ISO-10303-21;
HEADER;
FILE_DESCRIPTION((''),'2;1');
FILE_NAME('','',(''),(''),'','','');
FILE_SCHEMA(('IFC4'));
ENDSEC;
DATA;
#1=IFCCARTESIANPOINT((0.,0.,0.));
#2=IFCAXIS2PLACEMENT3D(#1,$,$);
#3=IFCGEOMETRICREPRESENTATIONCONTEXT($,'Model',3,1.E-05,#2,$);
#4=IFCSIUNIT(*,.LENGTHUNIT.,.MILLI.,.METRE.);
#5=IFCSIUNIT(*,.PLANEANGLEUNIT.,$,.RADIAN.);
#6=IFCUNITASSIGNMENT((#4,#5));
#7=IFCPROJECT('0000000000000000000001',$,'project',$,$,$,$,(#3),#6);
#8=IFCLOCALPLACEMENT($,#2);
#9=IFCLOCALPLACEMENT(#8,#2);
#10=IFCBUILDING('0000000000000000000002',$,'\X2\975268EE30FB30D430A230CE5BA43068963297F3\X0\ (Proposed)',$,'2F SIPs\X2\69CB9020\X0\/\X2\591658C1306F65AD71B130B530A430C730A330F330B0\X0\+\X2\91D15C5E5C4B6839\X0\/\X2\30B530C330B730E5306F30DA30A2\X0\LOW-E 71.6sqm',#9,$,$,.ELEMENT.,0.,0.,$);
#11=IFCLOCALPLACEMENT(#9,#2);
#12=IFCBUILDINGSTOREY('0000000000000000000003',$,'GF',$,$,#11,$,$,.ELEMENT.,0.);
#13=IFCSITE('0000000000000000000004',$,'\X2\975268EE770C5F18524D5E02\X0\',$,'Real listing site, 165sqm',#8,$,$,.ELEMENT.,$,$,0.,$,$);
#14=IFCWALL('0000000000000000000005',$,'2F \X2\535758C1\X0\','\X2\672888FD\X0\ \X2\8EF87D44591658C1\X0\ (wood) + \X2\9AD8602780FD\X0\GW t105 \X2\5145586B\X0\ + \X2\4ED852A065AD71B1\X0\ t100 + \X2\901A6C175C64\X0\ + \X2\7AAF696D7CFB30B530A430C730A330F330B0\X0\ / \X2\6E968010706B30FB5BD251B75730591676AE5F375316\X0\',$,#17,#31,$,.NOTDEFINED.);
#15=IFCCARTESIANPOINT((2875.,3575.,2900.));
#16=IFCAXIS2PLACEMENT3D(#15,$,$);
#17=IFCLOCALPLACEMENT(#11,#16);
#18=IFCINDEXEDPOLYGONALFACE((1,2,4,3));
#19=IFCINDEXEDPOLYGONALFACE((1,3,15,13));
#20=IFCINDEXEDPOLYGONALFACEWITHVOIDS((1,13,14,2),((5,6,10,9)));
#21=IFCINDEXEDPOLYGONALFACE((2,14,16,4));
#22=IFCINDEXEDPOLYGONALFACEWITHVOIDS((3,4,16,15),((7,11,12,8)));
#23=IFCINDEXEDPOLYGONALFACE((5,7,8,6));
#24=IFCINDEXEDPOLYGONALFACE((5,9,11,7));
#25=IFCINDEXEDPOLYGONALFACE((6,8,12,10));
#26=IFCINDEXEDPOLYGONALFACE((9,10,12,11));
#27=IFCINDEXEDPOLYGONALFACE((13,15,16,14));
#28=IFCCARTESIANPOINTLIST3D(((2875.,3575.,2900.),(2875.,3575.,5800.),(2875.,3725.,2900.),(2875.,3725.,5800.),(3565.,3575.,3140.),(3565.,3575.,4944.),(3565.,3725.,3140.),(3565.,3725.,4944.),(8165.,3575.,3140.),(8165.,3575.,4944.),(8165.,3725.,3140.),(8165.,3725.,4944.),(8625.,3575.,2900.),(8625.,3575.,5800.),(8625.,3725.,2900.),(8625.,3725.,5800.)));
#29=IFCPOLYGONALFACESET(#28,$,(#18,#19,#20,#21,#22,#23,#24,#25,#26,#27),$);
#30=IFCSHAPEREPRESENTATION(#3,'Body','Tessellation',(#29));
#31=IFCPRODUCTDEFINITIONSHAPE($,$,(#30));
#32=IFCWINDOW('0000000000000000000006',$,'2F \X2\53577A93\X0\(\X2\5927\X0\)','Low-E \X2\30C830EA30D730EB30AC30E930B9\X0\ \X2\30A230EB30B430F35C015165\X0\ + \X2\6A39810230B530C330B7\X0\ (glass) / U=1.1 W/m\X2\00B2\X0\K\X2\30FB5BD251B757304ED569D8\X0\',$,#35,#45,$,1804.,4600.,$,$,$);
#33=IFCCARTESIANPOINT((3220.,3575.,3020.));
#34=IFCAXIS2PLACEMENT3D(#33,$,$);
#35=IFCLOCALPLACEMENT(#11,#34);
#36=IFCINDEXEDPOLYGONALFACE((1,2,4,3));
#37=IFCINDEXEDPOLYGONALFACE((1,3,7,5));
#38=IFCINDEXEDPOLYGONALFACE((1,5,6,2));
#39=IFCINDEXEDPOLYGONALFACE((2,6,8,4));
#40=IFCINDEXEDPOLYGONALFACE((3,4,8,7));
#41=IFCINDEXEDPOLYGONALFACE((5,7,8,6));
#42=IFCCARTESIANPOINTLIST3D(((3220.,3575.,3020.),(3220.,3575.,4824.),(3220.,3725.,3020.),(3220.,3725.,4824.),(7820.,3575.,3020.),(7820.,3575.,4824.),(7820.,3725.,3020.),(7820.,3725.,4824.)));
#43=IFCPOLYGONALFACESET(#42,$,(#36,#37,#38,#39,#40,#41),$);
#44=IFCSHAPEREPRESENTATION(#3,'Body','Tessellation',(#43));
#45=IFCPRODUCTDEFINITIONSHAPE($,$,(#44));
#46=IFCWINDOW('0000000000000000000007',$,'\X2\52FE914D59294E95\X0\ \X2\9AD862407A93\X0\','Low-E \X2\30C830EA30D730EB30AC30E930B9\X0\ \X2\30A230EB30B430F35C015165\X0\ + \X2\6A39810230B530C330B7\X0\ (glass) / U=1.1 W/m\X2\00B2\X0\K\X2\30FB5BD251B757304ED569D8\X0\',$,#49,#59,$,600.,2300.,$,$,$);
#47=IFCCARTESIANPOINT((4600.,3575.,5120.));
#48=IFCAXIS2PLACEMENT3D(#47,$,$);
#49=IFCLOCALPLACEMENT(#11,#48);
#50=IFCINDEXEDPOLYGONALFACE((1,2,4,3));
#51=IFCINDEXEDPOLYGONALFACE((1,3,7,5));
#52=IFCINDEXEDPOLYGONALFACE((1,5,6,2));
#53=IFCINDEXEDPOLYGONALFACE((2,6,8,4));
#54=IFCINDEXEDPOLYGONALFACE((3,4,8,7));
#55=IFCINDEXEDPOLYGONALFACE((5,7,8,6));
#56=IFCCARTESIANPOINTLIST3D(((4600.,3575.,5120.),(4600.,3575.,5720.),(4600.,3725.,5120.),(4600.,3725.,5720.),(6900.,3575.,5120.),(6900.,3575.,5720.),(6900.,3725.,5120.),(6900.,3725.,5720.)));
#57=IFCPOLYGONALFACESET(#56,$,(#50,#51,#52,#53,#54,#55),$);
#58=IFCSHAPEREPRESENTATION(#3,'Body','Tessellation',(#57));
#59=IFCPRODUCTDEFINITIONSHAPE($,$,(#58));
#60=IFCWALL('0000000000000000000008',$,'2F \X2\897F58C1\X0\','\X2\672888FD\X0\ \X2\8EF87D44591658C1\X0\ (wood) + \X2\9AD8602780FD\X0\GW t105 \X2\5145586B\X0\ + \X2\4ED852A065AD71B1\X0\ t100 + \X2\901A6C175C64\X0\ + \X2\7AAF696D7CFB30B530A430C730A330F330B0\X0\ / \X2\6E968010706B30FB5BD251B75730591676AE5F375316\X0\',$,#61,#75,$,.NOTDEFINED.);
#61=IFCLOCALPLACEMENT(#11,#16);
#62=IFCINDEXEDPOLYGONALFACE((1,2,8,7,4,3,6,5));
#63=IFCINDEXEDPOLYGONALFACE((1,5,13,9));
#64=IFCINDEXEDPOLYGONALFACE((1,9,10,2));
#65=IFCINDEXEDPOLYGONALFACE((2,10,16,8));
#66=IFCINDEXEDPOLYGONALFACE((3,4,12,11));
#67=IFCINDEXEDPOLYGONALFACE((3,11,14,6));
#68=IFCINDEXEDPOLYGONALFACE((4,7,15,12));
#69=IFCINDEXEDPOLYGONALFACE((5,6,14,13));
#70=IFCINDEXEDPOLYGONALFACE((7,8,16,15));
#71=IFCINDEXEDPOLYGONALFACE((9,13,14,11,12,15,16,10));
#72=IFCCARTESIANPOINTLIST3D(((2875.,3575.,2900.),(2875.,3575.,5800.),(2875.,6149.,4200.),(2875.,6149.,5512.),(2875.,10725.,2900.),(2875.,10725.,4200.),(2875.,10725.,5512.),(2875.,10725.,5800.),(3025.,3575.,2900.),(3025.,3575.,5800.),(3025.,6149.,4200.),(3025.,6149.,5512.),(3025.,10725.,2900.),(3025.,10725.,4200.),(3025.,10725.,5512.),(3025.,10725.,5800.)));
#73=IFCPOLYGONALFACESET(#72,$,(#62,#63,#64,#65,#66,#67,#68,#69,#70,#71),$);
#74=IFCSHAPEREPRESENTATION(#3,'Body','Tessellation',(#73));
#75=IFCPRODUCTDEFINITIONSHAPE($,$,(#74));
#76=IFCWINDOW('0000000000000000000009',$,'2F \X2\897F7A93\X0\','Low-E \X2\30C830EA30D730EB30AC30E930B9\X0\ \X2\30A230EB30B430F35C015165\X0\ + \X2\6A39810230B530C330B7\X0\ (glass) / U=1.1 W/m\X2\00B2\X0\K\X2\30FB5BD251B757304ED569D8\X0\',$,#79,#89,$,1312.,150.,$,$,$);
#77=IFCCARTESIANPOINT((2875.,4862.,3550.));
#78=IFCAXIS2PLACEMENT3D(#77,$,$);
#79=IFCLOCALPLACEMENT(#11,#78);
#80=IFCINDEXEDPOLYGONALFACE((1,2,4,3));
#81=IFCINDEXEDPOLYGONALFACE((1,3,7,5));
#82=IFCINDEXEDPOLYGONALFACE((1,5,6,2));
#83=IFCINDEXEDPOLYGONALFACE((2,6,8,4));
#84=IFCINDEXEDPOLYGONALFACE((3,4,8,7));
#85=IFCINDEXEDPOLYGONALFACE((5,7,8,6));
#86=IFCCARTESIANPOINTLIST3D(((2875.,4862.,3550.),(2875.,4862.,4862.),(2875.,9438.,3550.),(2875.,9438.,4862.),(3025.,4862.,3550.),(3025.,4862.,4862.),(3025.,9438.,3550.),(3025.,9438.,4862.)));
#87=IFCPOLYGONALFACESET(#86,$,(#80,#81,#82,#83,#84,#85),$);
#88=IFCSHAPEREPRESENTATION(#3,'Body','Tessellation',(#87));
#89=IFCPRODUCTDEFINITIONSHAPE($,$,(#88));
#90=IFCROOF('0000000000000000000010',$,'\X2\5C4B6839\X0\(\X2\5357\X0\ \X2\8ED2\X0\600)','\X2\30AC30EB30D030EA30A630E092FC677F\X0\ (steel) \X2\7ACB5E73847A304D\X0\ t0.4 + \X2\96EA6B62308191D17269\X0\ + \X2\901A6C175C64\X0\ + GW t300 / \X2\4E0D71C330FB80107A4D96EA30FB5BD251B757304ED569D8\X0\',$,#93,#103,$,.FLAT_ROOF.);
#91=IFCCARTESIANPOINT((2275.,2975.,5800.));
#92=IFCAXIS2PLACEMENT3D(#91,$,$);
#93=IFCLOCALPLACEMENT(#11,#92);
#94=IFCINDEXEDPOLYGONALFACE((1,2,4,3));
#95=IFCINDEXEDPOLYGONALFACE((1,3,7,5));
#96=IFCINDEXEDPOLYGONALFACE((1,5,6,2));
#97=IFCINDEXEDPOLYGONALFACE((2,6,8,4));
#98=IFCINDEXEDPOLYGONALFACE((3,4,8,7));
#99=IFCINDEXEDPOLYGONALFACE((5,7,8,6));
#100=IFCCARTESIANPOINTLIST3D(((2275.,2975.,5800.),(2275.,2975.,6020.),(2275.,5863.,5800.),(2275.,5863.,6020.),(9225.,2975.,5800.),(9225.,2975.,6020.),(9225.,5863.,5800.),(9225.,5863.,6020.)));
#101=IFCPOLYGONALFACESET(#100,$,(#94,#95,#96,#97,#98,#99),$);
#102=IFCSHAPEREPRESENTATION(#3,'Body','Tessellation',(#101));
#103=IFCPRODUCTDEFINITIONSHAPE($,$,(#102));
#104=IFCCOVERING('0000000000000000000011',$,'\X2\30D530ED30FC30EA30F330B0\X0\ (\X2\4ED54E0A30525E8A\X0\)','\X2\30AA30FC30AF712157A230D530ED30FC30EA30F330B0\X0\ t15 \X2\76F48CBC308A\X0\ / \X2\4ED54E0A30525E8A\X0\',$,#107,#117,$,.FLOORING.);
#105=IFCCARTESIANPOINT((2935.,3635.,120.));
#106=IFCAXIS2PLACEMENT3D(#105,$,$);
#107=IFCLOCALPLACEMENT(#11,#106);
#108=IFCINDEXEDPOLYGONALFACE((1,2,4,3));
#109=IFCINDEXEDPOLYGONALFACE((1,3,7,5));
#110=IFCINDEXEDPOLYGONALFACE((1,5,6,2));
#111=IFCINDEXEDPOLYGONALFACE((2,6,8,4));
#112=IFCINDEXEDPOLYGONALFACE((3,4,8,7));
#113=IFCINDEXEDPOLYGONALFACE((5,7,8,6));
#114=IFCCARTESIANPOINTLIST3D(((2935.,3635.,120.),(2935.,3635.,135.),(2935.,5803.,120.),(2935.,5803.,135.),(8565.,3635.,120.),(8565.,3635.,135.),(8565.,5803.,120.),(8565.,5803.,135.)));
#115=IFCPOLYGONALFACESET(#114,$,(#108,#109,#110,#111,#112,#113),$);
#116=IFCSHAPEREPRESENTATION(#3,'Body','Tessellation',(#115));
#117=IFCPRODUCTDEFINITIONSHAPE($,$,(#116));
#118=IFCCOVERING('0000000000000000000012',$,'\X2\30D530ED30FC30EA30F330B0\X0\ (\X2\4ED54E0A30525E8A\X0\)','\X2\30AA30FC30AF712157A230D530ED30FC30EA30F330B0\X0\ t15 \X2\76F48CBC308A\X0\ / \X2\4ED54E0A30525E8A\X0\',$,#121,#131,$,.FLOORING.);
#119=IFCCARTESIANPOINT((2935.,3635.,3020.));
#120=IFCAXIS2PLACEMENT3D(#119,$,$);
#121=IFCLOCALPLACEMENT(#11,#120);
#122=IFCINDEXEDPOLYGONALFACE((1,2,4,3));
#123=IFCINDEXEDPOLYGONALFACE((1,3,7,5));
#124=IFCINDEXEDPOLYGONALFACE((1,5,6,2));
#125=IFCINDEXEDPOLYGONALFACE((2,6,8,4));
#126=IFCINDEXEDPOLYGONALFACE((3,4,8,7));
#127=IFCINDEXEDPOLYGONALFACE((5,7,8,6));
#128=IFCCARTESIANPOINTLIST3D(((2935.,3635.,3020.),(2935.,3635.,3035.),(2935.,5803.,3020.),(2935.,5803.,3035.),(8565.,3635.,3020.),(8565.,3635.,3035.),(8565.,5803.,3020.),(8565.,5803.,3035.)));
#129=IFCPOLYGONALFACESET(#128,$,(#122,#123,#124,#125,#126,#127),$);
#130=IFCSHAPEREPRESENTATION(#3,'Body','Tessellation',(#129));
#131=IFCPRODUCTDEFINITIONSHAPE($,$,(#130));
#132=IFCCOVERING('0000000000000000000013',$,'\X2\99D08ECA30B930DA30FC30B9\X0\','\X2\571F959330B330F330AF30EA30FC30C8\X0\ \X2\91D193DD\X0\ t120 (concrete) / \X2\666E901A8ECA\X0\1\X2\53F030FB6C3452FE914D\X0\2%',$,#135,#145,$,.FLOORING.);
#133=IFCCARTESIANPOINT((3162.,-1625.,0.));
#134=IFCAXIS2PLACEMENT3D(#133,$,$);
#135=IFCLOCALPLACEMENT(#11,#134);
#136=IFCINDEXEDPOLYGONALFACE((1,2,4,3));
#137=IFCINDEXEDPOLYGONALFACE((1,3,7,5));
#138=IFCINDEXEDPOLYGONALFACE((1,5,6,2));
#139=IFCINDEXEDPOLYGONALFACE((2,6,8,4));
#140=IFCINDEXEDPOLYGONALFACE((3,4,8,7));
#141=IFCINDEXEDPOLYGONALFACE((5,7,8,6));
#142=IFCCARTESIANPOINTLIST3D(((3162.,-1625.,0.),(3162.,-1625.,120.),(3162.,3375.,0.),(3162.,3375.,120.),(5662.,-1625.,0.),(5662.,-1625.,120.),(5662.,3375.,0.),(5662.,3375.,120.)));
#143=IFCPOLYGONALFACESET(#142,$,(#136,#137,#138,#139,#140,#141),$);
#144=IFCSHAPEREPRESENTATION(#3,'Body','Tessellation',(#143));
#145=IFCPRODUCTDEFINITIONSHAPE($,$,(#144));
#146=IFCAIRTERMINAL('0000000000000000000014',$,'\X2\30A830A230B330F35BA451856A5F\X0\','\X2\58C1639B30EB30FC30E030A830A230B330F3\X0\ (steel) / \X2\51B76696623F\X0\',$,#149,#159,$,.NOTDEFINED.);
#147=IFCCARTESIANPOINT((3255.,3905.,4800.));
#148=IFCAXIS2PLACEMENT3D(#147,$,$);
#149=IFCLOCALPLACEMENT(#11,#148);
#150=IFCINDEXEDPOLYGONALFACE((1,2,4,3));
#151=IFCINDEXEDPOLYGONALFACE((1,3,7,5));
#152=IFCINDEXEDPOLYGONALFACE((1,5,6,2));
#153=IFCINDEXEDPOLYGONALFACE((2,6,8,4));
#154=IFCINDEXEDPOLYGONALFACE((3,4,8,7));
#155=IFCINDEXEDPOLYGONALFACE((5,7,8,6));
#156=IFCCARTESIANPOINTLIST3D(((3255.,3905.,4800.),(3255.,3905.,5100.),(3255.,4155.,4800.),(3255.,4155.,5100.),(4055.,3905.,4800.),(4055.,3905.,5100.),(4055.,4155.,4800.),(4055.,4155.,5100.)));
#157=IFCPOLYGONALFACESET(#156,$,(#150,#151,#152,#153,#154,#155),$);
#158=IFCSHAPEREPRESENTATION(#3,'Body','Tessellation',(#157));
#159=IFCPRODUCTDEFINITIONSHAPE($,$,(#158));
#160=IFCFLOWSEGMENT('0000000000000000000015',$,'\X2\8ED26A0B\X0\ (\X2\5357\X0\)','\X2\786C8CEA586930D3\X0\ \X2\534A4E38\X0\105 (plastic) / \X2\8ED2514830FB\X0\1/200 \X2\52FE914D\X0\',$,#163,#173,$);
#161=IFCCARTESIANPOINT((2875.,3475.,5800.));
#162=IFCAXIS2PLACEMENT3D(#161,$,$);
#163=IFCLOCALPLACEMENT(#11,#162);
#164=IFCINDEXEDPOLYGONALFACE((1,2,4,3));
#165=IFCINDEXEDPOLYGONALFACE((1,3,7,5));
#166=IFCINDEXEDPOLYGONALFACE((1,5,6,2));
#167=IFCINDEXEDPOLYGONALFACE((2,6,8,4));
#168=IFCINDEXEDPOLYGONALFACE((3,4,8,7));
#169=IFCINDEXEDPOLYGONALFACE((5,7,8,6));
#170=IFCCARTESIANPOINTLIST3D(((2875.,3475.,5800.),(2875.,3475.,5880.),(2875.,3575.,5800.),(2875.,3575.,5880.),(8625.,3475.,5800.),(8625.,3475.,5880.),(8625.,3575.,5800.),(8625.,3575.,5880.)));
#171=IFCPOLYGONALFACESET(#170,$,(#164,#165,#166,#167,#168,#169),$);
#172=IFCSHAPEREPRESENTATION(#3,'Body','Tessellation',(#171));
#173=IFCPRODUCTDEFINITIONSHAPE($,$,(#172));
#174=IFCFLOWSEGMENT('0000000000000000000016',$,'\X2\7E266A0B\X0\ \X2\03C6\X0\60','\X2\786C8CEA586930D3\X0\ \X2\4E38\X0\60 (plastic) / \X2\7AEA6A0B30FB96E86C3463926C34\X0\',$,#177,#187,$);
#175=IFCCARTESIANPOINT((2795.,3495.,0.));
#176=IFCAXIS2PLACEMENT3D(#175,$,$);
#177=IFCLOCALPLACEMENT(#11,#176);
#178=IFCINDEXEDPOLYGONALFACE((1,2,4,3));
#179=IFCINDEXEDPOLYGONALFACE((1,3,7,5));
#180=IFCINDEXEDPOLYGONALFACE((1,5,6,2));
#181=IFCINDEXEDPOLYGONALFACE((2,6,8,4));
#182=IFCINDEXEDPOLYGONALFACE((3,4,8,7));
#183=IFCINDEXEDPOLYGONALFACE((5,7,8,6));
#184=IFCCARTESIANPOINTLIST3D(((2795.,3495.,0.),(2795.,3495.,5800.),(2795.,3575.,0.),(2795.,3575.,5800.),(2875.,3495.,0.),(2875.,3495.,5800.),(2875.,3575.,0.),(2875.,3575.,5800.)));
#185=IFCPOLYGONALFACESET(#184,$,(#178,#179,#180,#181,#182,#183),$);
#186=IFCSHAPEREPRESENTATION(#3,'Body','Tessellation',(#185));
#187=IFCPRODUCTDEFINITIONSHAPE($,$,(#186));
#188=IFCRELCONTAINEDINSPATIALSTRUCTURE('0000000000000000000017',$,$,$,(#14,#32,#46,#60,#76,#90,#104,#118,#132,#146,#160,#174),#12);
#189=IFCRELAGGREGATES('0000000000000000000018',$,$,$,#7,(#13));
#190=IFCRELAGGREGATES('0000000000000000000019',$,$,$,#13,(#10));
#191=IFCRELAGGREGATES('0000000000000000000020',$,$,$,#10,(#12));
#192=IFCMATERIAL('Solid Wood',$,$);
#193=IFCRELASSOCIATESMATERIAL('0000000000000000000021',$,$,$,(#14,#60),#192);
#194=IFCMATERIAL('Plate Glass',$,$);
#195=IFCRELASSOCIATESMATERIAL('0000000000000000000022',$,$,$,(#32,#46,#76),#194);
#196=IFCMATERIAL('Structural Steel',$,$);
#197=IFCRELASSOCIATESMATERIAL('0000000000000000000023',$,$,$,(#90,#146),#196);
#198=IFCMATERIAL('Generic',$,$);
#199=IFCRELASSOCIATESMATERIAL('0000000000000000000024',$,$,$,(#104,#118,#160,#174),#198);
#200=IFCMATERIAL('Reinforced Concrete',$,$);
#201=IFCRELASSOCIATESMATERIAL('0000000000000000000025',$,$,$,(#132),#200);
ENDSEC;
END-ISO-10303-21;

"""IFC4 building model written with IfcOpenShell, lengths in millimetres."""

from ifc_helpers import new_model, si_unit, frame, frame_2d, origin, place, context, project, spatial, rectangle, extrude, material, element, fill, save


model = new_model("IFC4")

# Units and contexts
model_context = context("Model", 3, precision=1e-05, world=origin())
ifc_project = project(units=[si_unit("LENGTHUNIT", "METRE", prefix="MILLI"), si_unit("PLANEANGLEUNIT", "RADIAN")], contexts=[model_context])

# Site, building, storey
site_placement = place(None, origin())
site = spatial("IfcSite", under=ifc_project, at=site_placement, Name="青森県弘前市", ObjectType="Real listing site, 165sqm", CompositionType="ELEMENT", RefElevation=0.0)
building_placement = place(site_placement, origin())
building = spatial("IfcBuilding", under=site, at=building_placement, Name="青森・ピアノ室と防音 (Proposed)", ObjectType="2F SIPs構造/外壁は断熱サイディング+金属屋根/サッシュはペアLOW-E 71.6sqm", CompositionType="ELEMENT", ElevationOfRefHeight=0.0, ElevationOfTerrain=0.0)
storey_placement = place(building_placement, origin())
storey = spatial("IfcBuildingStorey", under=building, at=storey_placement, Name="GF", CompositionType="ELEMENT", Elevation=0.0)

# Shared definitions
ifc_material_1 = material(Name="Solid Wood")

# Shared definitions
ifc_material_2 = material(Name="Reinforced Concrete")

# Shared definitions
ifc_material_3 = material(Name="Plate Glass")

# Wall, openings, windows
wall_1_placement = place(storey_placement, frame((2875.0, 3575.0, 2900.0)))
wall_1 = element("IfcWall", 1, at=wall_1_placement, inside=storey, material=ifc_material_1, Name="2F 南壁", Description="木製 軸組外壁 (wood) + 高性能GW t105 充填 + 付加断熱 t100 + 通気層 + 窯業系サイディング / 準耐火・寒冷地外皮強化", PredefinedType="NOTDEFINED", context=model_context, shape_type="SweptSolid", body=[
    extrude(rectangle(XDim=5750.0, YDim=150.0, at=frame_2d((2875.0, 75.0))), frame((2875.0, 3575.0, 2900.0)), (0.0, 0.0, 1.0), 2900.0),
])
opening_1_placement = place(storey_placement, frame((3220.0, 3575.0, 3020.0)))
opening_1 = element("IfcOpeningElement", 2, at=opening_1_placement, cuts=wall_1, PredefinedType="NOTDEFINED", context=model_context, shape_type="SweptSolid", body=[
    extrude(rectangle(XDim=4600.0, YDim=150.0, at=frame_2d((2300.0, 75.0))), frame((3220.0, 3575.0, 3020.0)), (0.0, 0.0, 1.0), 1804.0),
])
opening_2_placement = place(storey_placement, frame((4600.0, 3575.0, 5120.0)))
opening_2 = element("IfcOpeningElement", 3, at=opening_2_placement, cuts=wall_1, PredefinedType="NOTDEFINED", context=model_context, shape_type="SweptSolid", body=[
    extrude(rectangle(XDim=2300.0, YDim=150.0, at=frame_2d((1150.0, 75.0))), frame((4600.0, 3575.0, 5120.0)), (0.0, 0.0, 1.0), 600.0),
])
window_1_placement = place(storey_placement, frame((3220.0, 3575.0, 3020.0)))
window_1 = element("IfcWindow", 4, at=window_1_placement, inside=storey, material=ifc_material_3, Name="2F 南窓(大)", Description="Low-E トリプルガラス アルゴン封入 + 樹脂サッシ (glass) / U=1.1 W/m²K・寒冷地仕様", OverallHeight=1804.0, OverallWidth=4600.0, context=model_context, shape_type="SweptSolid", body=[
    extrude(rectangle(XDim=4600.0, YDim=150.0, at=frame_2d((2300.0, 75.0))), frame((3220.0, 3575.0, 3020.0)), (0.0, 0.0, 1.0), 1804.0),
])
fill(opening_1, window_1)
window_2_placement = place(storey_placement, frame((4600.0, 3575.0, 5120.0)))
window_2 = element("IfcWindow", 5, at=window_2_placement, inside=storey, material=ifc_material_3, Name="勾配天井 高所窓", Description="Low-E トリプルガラス アルゴン封入 + 樹脂サッシ (glass) / U=1.1 W/m²K・寒冷地仕様", OverallHeight=600.0, OverallWidth=2300.0, context=model_context, shape_type="SweptSolid", body=[
    extrude(rectangle(XDim=2300.0, YDim=150.0, at=frame_2d((1150.0, 75.0))), frame((4600.0, 3575.0, 5120.0)), (0.0, 0.0, 1.0), 600.0),
])
fill(opening_2, window_2)

# Wall, opening, window
wall_2_placement = place(storey_placement, frame((2875.0, 3575.0, 2900.0)))
wall_2 = element("IfcWall", 6, at=wall_2_placement, inside=storey, material=ifc_material_1, Name="2F 西壁", Description="木製 軸組外壁 (wood) + 高性能GW t105 充填 + 付加断熱 t100 + 通気層 + 窯業系サイディング / 準耐火・寒冷地外皮強化", PredefinedType="NOTDEFINED", context=model_context, shape_type="SweptSolid", body=[
    extrude(rectangle(XDim=150.0, YDim=7150.0, at=frame_2d((75.0, 3575.0))), frame((2875.0, 3575.0, 2900.0)), (0.0, 0.0, 1.0), 2900.0),
])
opening_3_placement = place(storey_placement, frame((2875.0, 4862.0, 3550.0)))
opening_3 = element("IfcOpeningElement", 7, at=opening_3_placement, cuts=wall_2, PredefinedType="NOTDEFINED", context=model_context, shape_type="SweptSolid", body=[
    extrude(rectangle(XDim=150.0, YDim=4576.0, at=frame_2d((75.0, 2288.0))), frame((2875.0, 4862.0, 3550.0)), (0.0, 0.0, 1.0), 1312.0),
])
window_3_placement = place(storey_placement, frame((2875.0, 4862.0, 3550.0)))
window_3 = element("IfcWindow", 8, at=window_3_placement, inside=storey, material=ifc_material_3, Name="2F 西窓", Description="Low-E トリプルガラス アルゴン封入 + 樹脂サッシ (glass) / U=1.1 W/m²K・寒冷地仕様", OverallHeight=1312.0, OverallWidth=150.0, context=model_context, shape_type="SweptSolid", body=[
    extrude(rectangle(XDim=150.0, YDim=4576.0, at=frame_2d((75.0, 2288.0))), frame((2875.0, 4862.0, 3550.0)), (0.0, 0.0, 1.0), 1312.0),
])
fill(opening_3, window_3)

# Roof
ifc_material_4 = material(Name="Structural Steel")
for number, where, name in (
    (9, (2275.0, 2975.0, 5800.0), "屋根(南 軒600)"),
):
    element("IfcRoof", number, at=place(storey_placement, frame(where)), inside=storey, material=ifc_material_4, Name=name, Description="ガルバリウム鋼板 (steel) 立平葺き t0.4 + 雪止め金物 + 通気層 + GW t300 / 不燃・耐積雪・寒冷地仕様", PredefinedType="FLAT_ROOF", context=model_context, shape_type="SweptSolid", body=[
        extrude(rectangle(XDim=6950.0, YDim=2888.0, at=frame_2d((3475.0, 1444.0))), frame((2275.0, 2975.0, 5800.0)), (0.0, 0.0, 1.0), 220.0),
    ])

# Coverings
ifc_material_5 = material(Name="Generic")
covering_1_placement = place(storey_placement, frame((2935.0, 3635.0, 120.0)))
element("IfcCovering", 10, at=covering_1_placement, inside=storey, material=ifc_material_5, Name="フローリング (仕上げ床)", Description="オーク無垢フローリング t15 直貼り / 仕上げ床", PredefinedType="FLOORING", context=model_context, shape_type="SweptSolid", body=[
    extrude(rectangle(XDim=5630.0, YDim=2168.0, at=frame_2d((2815.0, 1084.0))), frame((2935.0, 3635.0, 120.0)), (0.0, 0.0, 1.0), 15.0),
])
covering_2_placement = place(storey_placement, frame((2935.0, 3635.0, 3020.0)))
element("IfcCovering", 11, at=covering_2_placement, inside=storey, material=ifc_material_5, Name="フローリング (仕上げ床)", Description="オーク無垢フローリング t15 直貼り / 仕上げ床", PredefinedType="FLOORING", context=model_context, shape_type="SweptSolid", body=[
    extrude(rectangle(XDim=5630.0, YDim=2168.0, at=frame_2d((2815.0, 1084.0))), frame((2935.0, 3635.0, 3020.0)), (0.0, 0.0, 1.0), 15.0),
])
covering_3_placement = place(storey_placement, frame((3162.0, -1625.0, 0.0)))
element("IfcCovering", 12, at=covering_3_placement, inside=storey, material=ifc_material_2, Name="駐車スペース", Description="土間コンクリート 金鏝 t120 (concrete) / 普通車1台・水勾配2%", PredefinedType="FLOORING", context=model_context, shape_type="SweptSolid", body=[
    extrude(rectangle(XDim=2500.0, YDim=5000.0, at=frame_2d((1250.0, 2500.0))), frame((3162.0, -1625.0, 0.0)), (0.0, 0.0, 1.0), 120.0),
])

# Air terminal
air_terminal_placement = place(storey_placement, frame((3255.0, 3905.0, 4800.0)))
element("IfcAirTerminal", 13, at=air_terminal_placement, inside=storey, material=ifc_material_4, Name="エアコン室内機", Description="壁掛ルームエアコン (steel) / 冷暖房", PredefinedType="NOTDEFINED", context=model_context, shape_type="SweptSolid", body=[
    extrude(rectangle(XDim=800.0, YDim=250.0, at=frame_2d((400.0, 125.0))), frame((3255.0, 3905.0, 4800.0)), (0.0, 0.0, 1.0), 300.0),
])

# Flow segments
flow_segment_1_placement = place(storey_placement, frame((2875.0, 3475.0, 5800.0)))
element("IfcFlowSegment", 14, at=flow_segment_1_placement, inside=storey, material=ifc_material_5, Name="軒樋 (南)", Description="硬質塩ビ 半丸105 (plastic) / 軒先・1/200 勾配", context=model_context, shape_type="SweptSolid", body=[
    extrude(rectangle(XDim=5750.0, YDim=100.0, at=frame_2d((2875.0, 50.0))), frame((2875.0, 3475.0, 5800.0)), (0.0, 0.0, 1.0), 80.0),
])
flow_segment_2_placement = place(storey_placement, frame((2795.0, 3495.0, 0.0)))
element("IfcFlowSegment", 15, at=flow_segment_2_placement, inside=storey, material=ifc_material_5, Name="縦樋 φ60", Description="硬質塩ビ 丸60 (plastic) / 竪樋・雨水排水", context=model_context, shape_type="SweptSolid", body=[
    extrude(rectangle(XDim=80.0, YDim=80.0, at=frame_2d((40.0, 40.0))), frame((2795.0, 3495.0, 0.0)), (0.0, 0.0, 1.0), 5800.0),
])

save(model, "model.ifc")
